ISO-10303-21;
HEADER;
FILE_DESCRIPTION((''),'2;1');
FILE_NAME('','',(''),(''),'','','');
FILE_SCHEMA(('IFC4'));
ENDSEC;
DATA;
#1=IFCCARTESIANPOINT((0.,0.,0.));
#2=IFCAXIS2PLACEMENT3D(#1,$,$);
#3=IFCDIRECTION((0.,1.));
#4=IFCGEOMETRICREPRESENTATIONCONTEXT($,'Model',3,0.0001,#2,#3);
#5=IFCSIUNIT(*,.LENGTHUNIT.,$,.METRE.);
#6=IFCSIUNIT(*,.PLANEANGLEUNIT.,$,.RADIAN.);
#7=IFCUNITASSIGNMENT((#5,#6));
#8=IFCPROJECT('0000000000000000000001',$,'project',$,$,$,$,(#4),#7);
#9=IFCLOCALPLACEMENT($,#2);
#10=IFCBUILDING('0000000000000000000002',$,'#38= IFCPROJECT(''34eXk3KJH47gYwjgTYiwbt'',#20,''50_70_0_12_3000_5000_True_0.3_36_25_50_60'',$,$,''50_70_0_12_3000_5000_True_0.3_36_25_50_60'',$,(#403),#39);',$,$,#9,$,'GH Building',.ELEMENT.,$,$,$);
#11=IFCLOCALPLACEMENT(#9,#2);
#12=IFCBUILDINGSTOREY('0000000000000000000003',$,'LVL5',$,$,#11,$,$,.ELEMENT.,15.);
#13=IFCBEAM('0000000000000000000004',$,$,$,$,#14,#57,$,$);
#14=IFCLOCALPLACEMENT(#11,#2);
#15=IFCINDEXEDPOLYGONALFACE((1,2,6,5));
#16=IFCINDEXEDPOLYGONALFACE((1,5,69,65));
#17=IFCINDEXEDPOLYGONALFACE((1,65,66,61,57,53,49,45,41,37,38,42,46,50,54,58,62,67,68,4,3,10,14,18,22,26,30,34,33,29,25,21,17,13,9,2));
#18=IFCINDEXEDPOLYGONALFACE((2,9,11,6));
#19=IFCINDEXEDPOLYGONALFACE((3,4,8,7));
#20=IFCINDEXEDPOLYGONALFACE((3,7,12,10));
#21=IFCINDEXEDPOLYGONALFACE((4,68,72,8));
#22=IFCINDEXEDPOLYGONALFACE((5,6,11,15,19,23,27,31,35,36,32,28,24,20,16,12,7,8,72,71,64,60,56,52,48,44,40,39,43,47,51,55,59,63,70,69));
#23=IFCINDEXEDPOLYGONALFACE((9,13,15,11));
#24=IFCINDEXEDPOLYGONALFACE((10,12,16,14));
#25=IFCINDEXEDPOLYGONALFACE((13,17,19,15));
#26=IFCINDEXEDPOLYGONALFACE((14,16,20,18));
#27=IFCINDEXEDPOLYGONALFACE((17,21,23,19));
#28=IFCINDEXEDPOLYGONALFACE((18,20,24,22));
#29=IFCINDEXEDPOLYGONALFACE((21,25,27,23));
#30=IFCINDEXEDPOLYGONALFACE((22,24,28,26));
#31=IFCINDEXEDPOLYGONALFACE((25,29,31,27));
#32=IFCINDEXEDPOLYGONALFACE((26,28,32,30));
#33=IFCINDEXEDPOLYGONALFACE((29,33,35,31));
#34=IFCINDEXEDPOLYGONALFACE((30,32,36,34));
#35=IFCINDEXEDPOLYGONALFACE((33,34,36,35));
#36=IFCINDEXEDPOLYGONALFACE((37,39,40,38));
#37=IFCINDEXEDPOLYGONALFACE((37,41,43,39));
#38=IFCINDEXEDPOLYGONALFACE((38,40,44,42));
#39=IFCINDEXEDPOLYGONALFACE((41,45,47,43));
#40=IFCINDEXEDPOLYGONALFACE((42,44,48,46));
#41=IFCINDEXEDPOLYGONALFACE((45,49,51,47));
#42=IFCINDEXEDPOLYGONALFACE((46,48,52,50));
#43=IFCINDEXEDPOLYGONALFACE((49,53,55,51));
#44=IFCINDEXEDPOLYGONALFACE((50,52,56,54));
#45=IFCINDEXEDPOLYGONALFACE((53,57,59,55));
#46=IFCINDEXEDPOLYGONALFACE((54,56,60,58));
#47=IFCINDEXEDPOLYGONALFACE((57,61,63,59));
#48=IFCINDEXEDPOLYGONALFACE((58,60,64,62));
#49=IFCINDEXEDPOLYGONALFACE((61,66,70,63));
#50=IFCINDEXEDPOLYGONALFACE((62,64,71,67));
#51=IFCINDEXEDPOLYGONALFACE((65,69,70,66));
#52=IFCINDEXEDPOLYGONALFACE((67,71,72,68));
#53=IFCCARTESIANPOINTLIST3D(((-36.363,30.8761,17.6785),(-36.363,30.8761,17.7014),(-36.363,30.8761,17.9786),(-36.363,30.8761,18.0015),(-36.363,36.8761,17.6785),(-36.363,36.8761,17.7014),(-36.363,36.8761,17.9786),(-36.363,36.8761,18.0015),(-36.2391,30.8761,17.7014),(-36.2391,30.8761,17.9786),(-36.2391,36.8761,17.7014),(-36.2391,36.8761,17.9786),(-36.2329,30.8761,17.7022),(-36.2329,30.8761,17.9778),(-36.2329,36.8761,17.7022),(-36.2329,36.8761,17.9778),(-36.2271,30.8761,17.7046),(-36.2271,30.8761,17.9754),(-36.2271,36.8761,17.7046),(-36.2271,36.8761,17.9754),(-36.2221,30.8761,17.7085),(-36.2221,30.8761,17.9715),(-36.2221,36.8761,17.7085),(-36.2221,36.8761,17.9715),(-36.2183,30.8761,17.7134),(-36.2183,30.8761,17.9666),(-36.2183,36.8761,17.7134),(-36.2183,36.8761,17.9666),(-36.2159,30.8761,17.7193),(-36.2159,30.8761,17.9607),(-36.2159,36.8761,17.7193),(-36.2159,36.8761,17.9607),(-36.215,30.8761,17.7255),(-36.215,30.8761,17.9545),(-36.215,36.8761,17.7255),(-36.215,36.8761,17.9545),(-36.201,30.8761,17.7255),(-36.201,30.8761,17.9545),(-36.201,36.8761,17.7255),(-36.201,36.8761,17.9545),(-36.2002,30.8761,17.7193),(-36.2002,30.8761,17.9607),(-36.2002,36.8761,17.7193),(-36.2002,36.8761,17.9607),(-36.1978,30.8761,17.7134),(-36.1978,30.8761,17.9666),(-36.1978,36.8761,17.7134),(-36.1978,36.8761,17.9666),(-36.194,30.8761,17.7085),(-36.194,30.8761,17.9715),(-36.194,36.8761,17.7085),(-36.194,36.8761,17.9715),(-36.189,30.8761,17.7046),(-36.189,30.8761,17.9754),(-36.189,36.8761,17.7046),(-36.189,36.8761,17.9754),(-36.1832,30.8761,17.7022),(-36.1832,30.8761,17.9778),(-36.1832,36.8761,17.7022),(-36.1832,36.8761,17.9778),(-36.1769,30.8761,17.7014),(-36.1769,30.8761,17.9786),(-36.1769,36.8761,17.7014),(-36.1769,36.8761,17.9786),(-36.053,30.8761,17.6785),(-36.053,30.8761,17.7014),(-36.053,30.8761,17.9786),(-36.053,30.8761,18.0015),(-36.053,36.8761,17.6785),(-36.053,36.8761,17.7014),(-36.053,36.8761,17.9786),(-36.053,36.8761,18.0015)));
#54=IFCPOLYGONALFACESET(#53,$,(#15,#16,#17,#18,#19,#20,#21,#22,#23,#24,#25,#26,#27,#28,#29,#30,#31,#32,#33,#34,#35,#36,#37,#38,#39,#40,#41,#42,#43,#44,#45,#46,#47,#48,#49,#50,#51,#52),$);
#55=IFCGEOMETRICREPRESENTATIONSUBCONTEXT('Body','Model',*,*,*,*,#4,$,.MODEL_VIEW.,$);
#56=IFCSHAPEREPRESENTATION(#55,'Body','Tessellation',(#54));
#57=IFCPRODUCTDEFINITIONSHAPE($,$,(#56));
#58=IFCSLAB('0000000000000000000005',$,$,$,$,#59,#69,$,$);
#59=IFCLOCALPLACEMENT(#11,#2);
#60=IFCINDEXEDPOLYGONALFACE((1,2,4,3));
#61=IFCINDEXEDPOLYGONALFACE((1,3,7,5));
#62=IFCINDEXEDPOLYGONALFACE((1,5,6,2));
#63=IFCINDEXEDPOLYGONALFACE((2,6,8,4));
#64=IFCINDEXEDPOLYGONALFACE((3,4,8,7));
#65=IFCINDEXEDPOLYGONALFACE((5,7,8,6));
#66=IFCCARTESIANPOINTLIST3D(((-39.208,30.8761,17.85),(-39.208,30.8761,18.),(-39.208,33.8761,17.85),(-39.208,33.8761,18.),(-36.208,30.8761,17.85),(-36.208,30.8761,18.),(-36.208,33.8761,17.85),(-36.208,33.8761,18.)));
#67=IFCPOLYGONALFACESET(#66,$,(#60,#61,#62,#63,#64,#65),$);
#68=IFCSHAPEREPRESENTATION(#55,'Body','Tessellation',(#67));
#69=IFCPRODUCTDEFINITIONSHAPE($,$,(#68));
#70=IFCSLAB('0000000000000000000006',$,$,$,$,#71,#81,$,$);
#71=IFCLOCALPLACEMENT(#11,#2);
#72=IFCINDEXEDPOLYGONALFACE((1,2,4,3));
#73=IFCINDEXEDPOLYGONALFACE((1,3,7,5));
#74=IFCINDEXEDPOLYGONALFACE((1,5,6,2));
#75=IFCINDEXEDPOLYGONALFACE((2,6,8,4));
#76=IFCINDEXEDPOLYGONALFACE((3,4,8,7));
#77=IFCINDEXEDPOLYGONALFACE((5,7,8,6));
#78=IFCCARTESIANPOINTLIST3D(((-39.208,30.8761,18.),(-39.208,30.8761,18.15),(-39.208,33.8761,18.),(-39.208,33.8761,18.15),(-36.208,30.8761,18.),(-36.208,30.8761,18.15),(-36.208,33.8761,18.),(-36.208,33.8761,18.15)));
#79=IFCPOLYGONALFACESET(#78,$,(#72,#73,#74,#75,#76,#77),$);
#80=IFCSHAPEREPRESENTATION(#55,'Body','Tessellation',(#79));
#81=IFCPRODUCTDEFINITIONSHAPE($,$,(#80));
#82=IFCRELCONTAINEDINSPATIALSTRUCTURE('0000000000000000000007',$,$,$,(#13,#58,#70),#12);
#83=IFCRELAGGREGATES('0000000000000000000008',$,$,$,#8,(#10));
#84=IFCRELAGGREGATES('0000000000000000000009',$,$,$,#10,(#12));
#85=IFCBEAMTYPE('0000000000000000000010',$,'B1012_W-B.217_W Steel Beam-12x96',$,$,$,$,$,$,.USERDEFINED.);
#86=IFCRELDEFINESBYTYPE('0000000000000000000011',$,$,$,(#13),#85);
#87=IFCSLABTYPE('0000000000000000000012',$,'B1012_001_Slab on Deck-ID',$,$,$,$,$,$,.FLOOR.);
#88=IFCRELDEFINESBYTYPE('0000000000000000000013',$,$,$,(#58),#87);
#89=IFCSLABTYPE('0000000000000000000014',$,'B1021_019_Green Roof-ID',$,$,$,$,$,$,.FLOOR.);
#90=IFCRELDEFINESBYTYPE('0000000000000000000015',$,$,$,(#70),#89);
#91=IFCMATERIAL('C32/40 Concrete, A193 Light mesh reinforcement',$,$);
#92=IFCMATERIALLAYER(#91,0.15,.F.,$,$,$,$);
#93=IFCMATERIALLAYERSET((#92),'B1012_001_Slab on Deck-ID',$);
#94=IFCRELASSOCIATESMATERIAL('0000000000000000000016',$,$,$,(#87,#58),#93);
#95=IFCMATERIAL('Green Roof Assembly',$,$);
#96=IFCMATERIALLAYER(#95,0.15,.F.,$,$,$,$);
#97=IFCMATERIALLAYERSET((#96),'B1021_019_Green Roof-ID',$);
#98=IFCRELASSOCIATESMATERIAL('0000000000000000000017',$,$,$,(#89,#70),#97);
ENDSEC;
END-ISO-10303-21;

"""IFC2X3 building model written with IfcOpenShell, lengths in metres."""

from ifc_helpers import new_model, si_unit, direction, frame, origin, origin_2d, place, context, subcontext, project, spatial, polyline, i_section, outline, extrude, material, layer, layer_set, layer_usage, type_object, element, save


model = new_model("IFC2X3")

# Units and contexts
model_context = context("Model", 3, precision=0.0001, world=origin(), true_north=direction((0.0, 1.0)))
body_context = subcontext(model_context, "Body", "Model", "MODEL_VIEW")
ifc_project = project(units=[si_unit("LENGTHUNIT", "METRE"), si_unit("PLANEANGLEUNIT", "RADIAN")], contexts=[model_context])

# Building, storey
building_placement = place(None, origin())
building = spatial("IfcBuilding", under=ifc_project, at=building_placement, Name="#38= IFCPROJECT('34eXk3KJH47gYwjgTYiwbt',#20,'50_70_0_12_3000_5000_True_0.3_36_25_50_60',$,$,'50_70_0_12_3000_5000_True_0.3_36_25_50_60',$,(#403),#39);", LongName="GH Building", CompositionType="ELEMENT")
storey_placement = place(building_placement, origin())
storey = spatial("IfcBuildingStorey", under=building, at=storey_placement, Name="LVL5", CompositionType="ELEMENT", Elevation=15.0)

# Beam
beam_type = type_object("IfcBeamType", Name="B1012_W-B.217_W Steel Beam-12x96", PredefinedType="USERDEFINED")
beam_placement = place(storey_placement, frame((-36.208, 30.8761, 17.84), z_axis=(0.0, 1.0, 0.0), x_axis=(-1.0, 0.0, 0.0)))
element("IfcBeam", 1, at=beam_placement, inside=storey, type_object=beam_type, context=body_context, shape_type="SweptSolid", body=[
    extrude(i_section(OverallWidth=0.31, OverallDepth=0.323, WebThickness=0.014, FlangeThickness=0.0229, FilletRadius=0.0241, at=origin_2d()), origin(), (0.0, 0.0, 1.0), 6.0),
])

# Slabs
ifc_material_1 = material(Name="C32/40 Concrete, A193 Light mesh reinforcement")
ifc_layer_1 = layer(ifc_material_1, 0.15, ventilated=False)
ifc_layer_set_1 = layer_set([ifc_layer_1], Name="B1012_001_Slab on Deck-ID")
ifc_layer_usage_1 = layer_usage(ifc_layer_set_1, "AXIS3", "NEGATIVE", -0.15)
slab_type_1 = type_object("IfcSlabType", Name="B1012_001_Slab on Deck-ID", PredefinedType="FLOOR", material=ifc_layer_set_1)
slab_1_placement = place(storey_placement, frame((-37.708, 32.3761, 17.85)))
element("IfcSlab", 2, at=slab_1_placement, inside=storey, type_object=slab_type_1, material=ifc_layer_usage_1, context=body_context, shape_type="SweptSolid", body=[
    extrude(outline(polyline([(1.5, -1.5), (-1.5, -1.5), (-1.5, 1.5), (1.5, 1.5), (1.5, -1.5)])), origin(), (0.0, 0.0, 1.0), 0.15),
])
ifc_material_2 = material(Name="Green Roof Assembly")
ifc_layer_2 = layer(ifc_material_2, 0.15, ventilated=False)
ifc_layer_set_2 = layer_set([ifc_layer_2], Name="B1021_019_Green Roof-ID")
ifc_layer_usage_2 = layer_usage(ifc_layer_set_2, "AXIS3", "NEGATIVE", -0.15)
slab_type_2 = type_object("IfcSlabType", Name="B1021_019_Green Roof-ID", PredefinedType="FLOOR", material=ifc_layer_set_2)
slab_2_placement = place(storey_placement, frame((-37.708, 32.3761, 18.0)))
element("IfcSlab", 3, at=slab_2_placement, inside=storey, type_object=slab_type_2, material=ifc_layer_usage_2, context=body_context, shape_type="SweptSolid", body=[
    extrude(outline(polyline([(1.5, -1.5), (-1.5, -1.5), (-1.5, 1.5), (1.5, 1.5), (1.5, -1.5)])), origin(), (0.0, 0.0, 1.0), 0.15),
])

save(model, "model.ifc")
